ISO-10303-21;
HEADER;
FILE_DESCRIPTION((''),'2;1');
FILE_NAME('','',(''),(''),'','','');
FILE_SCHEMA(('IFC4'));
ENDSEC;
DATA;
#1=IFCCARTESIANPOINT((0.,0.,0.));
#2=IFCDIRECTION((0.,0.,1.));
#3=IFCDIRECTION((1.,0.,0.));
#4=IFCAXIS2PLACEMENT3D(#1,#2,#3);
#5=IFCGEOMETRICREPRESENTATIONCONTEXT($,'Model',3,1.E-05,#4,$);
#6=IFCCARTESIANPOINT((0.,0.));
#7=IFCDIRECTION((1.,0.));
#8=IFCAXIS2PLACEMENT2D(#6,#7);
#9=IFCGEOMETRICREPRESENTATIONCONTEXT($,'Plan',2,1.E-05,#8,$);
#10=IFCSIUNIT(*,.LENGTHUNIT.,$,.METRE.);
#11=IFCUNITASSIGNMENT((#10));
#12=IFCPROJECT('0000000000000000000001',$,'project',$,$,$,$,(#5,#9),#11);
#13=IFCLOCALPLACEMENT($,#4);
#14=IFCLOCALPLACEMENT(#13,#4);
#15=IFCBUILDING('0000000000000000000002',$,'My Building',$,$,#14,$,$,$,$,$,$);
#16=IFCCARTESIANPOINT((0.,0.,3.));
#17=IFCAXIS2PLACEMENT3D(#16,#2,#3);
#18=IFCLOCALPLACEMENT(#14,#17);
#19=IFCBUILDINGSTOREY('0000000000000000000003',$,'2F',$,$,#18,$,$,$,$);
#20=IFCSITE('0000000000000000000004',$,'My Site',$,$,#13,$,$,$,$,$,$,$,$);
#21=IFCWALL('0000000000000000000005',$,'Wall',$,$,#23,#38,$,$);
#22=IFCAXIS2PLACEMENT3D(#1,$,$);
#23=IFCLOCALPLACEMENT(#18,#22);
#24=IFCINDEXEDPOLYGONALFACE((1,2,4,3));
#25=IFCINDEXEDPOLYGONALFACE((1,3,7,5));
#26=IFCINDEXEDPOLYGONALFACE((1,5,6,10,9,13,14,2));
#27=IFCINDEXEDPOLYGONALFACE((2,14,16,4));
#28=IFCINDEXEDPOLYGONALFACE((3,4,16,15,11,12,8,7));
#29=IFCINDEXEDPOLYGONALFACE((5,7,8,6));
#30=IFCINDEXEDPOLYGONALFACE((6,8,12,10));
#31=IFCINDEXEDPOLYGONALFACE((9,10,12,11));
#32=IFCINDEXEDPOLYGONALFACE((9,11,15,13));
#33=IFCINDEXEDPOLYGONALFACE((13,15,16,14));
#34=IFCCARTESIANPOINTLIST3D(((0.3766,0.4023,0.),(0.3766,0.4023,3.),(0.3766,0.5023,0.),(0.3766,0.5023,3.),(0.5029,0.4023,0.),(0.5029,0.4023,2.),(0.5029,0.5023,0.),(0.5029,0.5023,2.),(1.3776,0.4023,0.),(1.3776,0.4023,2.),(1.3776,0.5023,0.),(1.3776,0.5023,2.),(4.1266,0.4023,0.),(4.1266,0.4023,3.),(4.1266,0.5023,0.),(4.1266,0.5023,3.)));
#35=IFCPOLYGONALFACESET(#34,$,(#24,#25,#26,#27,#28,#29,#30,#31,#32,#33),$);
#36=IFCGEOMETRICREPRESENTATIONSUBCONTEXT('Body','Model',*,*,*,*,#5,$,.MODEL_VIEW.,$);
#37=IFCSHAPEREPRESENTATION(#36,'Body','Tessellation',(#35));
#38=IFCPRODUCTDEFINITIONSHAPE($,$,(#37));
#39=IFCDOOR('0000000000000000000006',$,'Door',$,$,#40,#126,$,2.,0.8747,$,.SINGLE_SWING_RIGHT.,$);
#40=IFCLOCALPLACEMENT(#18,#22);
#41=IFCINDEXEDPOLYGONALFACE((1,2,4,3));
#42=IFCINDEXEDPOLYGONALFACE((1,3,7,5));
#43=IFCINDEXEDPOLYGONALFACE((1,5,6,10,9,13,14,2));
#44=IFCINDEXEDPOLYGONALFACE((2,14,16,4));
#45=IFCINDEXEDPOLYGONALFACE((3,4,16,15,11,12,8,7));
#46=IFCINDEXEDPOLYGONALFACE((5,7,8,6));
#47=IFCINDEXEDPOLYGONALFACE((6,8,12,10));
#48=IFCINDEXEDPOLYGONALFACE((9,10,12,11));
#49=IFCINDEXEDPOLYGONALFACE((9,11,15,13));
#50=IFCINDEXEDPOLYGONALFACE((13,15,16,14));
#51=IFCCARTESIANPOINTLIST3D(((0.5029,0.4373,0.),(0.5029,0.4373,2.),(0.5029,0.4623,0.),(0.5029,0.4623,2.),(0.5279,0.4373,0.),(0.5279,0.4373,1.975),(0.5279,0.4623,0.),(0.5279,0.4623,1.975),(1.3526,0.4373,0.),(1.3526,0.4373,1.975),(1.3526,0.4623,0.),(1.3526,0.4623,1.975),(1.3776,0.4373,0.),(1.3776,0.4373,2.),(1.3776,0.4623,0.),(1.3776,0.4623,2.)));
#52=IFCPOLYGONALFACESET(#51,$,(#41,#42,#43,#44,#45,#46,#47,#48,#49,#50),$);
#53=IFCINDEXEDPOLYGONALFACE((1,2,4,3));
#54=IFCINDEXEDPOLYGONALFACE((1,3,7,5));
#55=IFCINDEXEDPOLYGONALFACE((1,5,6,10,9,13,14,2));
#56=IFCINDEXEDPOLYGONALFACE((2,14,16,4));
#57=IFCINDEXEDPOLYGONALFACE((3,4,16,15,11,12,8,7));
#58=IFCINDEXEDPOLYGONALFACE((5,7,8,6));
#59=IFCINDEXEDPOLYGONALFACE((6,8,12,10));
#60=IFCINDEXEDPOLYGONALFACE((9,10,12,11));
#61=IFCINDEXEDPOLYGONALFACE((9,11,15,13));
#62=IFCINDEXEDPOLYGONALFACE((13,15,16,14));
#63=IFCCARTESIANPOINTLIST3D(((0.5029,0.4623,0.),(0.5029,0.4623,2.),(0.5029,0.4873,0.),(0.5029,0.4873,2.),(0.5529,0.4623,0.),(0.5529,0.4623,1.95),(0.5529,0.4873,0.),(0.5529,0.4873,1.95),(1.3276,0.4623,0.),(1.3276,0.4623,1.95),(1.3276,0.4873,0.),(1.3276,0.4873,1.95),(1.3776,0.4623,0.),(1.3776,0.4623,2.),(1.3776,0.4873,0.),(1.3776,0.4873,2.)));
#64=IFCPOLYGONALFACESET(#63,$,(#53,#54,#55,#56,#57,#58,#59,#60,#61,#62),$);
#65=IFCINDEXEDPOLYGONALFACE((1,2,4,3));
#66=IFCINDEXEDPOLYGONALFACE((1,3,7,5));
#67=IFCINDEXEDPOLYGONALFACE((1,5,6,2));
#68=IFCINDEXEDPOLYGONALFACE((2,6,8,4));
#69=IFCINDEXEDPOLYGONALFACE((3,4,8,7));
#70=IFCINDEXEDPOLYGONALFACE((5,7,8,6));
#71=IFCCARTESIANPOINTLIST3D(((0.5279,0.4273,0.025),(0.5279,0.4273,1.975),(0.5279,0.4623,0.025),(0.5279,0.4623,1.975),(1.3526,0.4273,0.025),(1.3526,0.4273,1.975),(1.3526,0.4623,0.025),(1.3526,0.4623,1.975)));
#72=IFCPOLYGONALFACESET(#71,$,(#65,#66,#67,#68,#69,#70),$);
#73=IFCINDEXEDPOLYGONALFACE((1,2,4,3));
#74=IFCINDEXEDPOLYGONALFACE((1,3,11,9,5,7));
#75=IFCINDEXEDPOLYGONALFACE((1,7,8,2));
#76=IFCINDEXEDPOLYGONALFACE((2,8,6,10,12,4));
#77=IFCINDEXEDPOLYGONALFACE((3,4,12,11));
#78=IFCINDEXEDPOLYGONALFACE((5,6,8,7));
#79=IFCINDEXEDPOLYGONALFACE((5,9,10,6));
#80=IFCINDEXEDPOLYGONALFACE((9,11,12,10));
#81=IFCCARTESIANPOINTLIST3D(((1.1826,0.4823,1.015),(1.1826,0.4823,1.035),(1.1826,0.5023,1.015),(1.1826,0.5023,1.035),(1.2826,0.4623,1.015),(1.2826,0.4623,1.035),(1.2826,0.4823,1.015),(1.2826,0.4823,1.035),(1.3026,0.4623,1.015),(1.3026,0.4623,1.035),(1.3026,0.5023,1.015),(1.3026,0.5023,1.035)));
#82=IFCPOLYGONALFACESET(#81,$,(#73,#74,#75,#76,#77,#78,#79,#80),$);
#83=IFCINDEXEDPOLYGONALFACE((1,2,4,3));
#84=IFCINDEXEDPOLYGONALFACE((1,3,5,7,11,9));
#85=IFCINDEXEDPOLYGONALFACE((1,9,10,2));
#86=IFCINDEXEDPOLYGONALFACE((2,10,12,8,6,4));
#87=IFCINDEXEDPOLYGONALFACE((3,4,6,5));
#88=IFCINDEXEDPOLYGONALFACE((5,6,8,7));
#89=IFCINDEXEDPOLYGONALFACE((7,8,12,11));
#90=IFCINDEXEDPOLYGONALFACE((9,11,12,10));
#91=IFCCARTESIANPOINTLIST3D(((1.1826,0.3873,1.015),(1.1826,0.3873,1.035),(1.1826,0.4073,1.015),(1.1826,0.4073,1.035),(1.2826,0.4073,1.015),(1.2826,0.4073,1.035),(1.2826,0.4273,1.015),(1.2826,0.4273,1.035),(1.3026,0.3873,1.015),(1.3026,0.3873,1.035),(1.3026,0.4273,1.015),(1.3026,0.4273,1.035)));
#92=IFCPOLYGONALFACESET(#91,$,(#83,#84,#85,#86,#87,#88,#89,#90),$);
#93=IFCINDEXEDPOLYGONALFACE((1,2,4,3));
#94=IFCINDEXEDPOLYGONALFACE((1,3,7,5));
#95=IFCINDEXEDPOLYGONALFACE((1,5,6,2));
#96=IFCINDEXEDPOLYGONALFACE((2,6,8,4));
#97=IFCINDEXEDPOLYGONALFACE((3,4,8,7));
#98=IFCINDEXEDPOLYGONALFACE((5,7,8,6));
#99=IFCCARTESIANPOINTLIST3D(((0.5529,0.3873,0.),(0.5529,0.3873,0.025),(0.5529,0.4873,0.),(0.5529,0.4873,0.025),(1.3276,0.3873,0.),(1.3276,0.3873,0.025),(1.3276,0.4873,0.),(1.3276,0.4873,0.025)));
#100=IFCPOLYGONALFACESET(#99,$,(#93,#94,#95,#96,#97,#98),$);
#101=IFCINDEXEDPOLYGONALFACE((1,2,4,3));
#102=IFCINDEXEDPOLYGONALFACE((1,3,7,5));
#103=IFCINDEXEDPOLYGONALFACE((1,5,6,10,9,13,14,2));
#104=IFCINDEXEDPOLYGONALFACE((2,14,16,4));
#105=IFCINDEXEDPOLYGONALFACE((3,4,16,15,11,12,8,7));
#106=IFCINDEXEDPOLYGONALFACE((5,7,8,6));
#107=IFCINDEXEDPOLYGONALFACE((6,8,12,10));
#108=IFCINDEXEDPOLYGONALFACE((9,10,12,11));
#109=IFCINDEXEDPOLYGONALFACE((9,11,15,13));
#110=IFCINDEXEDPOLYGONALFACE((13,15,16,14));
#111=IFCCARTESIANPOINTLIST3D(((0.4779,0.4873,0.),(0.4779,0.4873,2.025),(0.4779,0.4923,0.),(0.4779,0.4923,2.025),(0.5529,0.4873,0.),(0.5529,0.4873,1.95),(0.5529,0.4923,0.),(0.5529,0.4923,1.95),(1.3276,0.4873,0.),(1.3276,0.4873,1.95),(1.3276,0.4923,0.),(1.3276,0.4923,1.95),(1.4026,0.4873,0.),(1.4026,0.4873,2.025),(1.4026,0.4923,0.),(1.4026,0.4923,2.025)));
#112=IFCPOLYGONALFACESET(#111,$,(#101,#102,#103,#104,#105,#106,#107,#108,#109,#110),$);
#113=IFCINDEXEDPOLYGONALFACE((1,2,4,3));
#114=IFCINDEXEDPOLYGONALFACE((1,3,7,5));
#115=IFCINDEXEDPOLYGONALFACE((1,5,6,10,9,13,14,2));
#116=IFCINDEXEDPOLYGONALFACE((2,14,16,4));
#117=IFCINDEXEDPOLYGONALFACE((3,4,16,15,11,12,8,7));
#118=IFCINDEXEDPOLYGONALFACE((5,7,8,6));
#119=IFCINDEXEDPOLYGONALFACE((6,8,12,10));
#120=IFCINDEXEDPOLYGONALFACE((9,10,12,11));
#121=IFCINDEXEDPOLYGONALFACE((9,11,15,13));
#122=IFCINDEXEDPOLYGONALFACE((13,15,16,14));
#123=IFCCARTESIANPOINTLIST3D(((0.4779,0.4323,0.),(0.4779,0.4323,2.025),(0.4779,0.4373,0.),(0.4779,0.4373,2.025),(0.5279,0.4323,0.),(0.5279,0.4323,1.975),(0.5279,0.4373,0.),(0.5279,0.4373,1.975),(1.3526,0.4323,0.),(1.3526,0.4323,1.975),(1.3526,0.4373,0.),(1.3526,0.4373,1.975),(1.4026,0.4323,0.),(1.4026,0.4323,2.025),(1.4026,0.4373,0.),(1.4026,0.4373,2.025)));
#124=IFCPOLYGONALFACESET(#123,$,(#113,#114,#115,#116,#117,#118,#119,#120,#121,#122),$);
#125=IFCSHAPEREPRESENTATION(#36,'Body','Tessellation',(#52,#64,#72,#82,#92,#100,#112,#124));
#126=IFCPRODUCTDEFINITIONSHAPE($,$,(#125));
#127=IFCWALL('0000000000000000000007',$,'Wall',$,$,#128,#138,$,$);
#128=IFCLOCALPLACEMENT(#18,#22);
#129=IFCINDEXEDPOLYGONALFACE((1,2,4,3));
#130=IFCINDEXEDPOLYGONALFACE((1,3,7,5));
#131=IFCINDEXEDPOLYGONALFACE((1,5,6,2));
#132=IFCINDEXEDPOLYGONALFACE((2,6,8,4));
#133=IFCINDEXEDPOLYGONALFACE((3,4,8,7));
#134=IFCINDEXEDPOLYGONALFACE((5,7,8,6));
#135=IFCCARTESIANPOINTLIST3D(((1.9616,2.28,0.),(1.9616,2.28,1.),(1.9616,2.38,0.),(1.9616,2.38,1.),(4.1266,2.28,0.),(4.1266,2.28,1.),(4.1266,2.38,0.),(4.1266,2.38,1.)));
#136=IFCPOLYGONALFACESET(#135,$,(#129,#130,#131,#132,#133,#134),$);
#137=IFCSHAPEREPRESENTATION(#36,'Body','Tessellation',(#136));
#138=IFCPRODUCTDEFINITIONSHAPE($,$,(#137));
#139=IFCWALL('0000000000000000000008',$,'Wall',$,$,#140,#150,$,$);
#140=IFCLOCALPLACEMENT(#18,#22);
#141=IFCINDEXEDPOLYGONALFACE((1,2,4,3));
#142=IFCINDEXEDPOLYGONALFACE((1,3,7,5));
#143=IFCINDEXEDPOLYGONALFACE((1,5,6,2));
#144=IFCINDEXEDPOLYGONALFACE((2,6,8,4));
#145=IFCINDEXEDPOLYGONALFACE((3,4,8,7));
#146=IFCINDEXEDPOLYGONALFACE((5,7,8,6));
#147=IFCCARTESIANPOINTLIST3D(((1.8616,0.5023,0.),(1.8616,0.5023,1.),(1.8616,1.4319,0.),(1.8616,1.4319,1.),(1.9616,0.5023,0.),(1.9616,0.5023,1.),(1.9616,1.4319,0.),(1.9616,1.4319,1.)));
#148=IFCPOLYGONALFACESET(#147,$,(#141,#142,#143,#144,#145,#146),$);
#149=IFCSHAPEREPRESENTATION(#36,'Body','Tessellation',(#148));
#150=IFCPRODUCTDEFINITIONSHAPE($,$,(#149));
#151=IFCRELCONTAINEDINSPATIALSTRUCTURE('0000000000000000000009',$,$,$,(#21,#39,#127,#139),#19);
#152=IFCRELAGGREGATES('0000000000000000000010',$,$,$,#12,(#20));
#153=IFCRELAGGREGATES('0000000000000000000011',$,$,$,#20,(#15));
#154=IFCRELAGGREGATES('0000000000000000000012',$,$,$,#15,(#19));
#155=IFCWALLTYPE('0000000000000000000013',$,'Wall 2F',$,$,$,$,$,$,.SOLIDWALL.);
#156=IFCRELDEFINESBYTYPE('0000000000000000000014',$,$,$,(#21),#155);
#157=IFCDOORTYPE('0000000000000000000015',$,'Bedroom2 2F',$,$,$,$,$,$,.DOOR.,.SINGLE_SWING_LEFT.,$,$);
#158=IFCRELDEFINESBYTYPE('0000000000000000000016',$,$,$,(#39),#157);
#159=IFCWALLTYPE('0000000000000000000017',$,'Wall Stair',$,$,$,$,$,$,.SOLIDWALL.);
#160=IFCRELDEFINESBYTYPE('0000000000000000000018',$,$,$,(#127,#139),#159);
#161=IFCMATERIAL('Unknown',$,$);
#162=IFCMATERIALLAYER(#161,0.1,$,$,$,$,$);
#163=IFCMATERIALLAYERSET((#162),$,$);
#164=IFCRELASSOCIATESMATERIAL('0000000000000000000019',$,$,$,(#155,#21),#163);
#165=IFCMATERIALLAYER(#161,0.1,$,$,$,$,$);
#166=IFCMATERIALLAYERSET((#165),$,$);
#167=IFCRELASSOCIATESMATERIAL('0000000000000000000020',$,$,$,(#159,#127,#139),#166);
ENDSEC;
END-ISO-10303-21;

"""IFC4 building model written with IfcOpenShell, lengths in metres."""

from ifc_helpers import new_model, entity, si_unit, frame, origin_with_axes, origin_2d_with_axis, place, context, subcontext, project, spatial, line, indexed_curve, outline, extrude, shape, source, transform, mapped, material, layer, layer_set, layer_usage, type_object, type_shapes, element, fill, save


model = new_model("IFC4")

# Units and contexts
model_context = context("Model", 3, precision=1e-05, world=origin_with_axes())
plan_context = context("Plan", 2, precision=1e-05, world=origin_2d_with_axis())
body_context_1 = subcontext(model_context, "Body", "Model", "MODEL_VIEW")
body_context_2 = subcontext(plan_context, "Body", "Plan", "PLAN_VIEW")
ifc_project = project(units=[si_unit("LENGTHUNIT", "METRE")], contexts=[model_context, plan_context])

# Site, building, storey
site_placement = place(None, origin_with_axes())
site = spatial("IfcSite", under=ifc_project, at=site_placement, Name="My Site")
building_placement = place(site_placement, origin_with_axes())
building = spatial("IfcBuilding", under=site, at=building_placement, Name="My Building")
storey_placement = place(building_placement, frame((0.0, 0.0, 3.0), z_axis=(0.0, 0.0, 1.0), x_axis=(1.0, 0.0, 0.0)))
storey = spatial("IfcBuildingStorey", under=building, at=storey_placement, Name="2F")

# Shared definitions
ifc_material = material(Name="Unknown")
ifc_layer_1 = layer(ifc_material, 0.1)
ifc_layer_set_1 = layer_set([ifc_layer_1])
wall_type_1 = type_object("IfcWallType", Name="Wall 2F", PredefinedType="SOLIDWALL", material=ifc_layer_set_1)

# Wall, opening, door
ifc_layer_usage_1 = layer_usage(ifc_layer_set_1, "AXIS2", "POSITIVE", 0.0)
wall_1_placement = place(storey_placement, frame((4.2266, 0.5023, 0.0), z_axis=(0.0, 0.0, 1.0), x_axis=(-1.0, 0.0, 0.0)))
wall_1 = element("IfcWall", 1, at=wall_1_placement, inside=storey, type_object=wall_type_1, material=ifc_layer_usage_1, Name="Wall", context=body_context_1, shape_type="SweptSolid", body=[
    extrude(outline(indexed_curve([(0.1, 0.0), (0.1, 0.1), (3.85, 0.1), (3.85, 0.0)], segments=[line(1, 2, 3, 4, 1)])), origin_with_axes(), (0.0, 0.0, 1.0), 3.0),
])
shared_shape_1 = source(origin_with_axes(), body_context_1, "Body", "SweptSolid", [
    extrude(outline(indexed_curve([(0.0, 0.0), (0.8747, 0.0), (0.8747, 2.0), (0.0, 2.0)], segments=[line(1, 2, 3, 4, 1)])), frame((0.0, -0.6, 0.0), z_axis=(0.0, -1.0, 0.0), x_axis=(1.0, 0.0, 0.0)), (0.0, 0.0, -1.0), 1.2),
])
opening_1_placement = place(wall_1_placement, frame((2.849, 0.015, 0.0), z_axis=(0.0, 0.0, 1.0), x_axis=(1.0, -0.000001, 0.0)))
opening_1 = element("IfcOpeningElement", 2, at=opening_1_placement, cuts=wall_1, PredefinedType="OPENING", context=body_context_1, shape_type="MappedRepresentation", body=[
    mapped(shared_shape_1, transform((0.0, 0.0, 0.0), x_axis=(1.0, 0.0, 0.0), y_axis=(0.0, 1.0, 0.0), z_axis=(0.0, 0.0, 1.0), scale=1.0)),
])
door_type_1 = type_object("IfcDoorType", Name="Bedroom2 2F", OperationType="SINGLE_SWING_LEFT", PredefinedType="DOOR")
shared_shape_2 = source(origin_with_axes(), body_context_1, "Body", "SweptSolid", [
    extrude(outline(indexed_curve([(0.0, 0.0), (0.0, 2.0), (0.8747, 2.0), (0.8747, 0.0), (0.8497, 0.0), (0.8497, 1.975), (0.025, 1.975), (0.025, 0.0)], segments=[line(1, 2, 3, 4, 5, 6, 7, 8, 1)])), frame((0.0, 0.025, 0.0), z_axis=(0.0, -1.0, 0.0), x_axis=(1.0, 0.0, 0.0)), (0.0, 0.0, -1.0), 0.025),
    extrude(outline(indexed_curve([(0.0, 0.0), (0.0, 2.0), (0.8747, 2.0), (0.8747, 0.0), (0.8247, 0.0), (0.8247, 1.95), (0.05, 1.95), (0.05, 0.0)], segments=[line(1, 2, 3, 4, 5, 6, 7, 8, 1)])), frame((0.0, 0.0, 0.0), z_axis=(0.0, -1.0, 0.0), x_axis=(1.0, 0.0, 0.0)), (0.0, 0.0, -1.0), 0.025),
    extrude(outline(indexed_curve([(0.0, 0.0), (0.8247, 0.0), (0.8247, 0.035), (0.0, 0.035)], segments=[line(1, 2, 3, 4, 1)])), frame((0.025, 0.025, 0.025), z_axis=(0.0, 0.0, 1.0), x_axis=(1.0, 0.0, 0.0)), (0.0, 0.0, 1.0), 1.95),
    extrude(outline(indexed_curve([(0.0, 0.0), (0.0, -0.04), (0.12, -0.04), (0.12, -0.02), (0.02, -0.02), (0.02, 0.0)], segments=[line(1, 2, 3, 4, 5, 6, 1)])), frame((0.075, 0.025, 1.015), z_axis=(0.0, 0.0, 1.0), x_axis=(1.0, 0.0, 0.0)), (0.0, 0.0, 1.0), 0.02),
    extrude(outline(indexed_curve([(0.0, 0.0), (0.0, 0.04), (0.12, 0.04), (0.12, 0.02), (0.02, 0.02), (0.02, 0.0)], segments=[line(1, 2, 3, 4, 5, 6, 1)])), frame((0.075, 0.06, 1.015), z_axis=(0.0, 0.0, 1.0), x_axis=(1.0, 0.0, 0.0)), (0.0, 0.0, 1.0), 0.02),
    extrude(outline(indexed_curve([(0.0, 0.0), (0.7747, 0.0), (0.7747, 0.1), (0.0, 0.1)], segments=[line(1, 2, 3, 4, 1)])), frame((0.05, 0.0, 0.0), z_axis=(0.0, 0.0, 1.0), x_axis=(1.0, 0.0, 0.0)), (0.0, 0.0, 1.0), 0.025),
    extrude(outline(indexed_curve([(0.0, 0.0), (0.0, 2.025), (0.9247, 2.025), (0.9247, 0.0), (0.8497, 0.0), (0.8497, 1.95), (0.075, 1.95), (0.075, 0.0)], segments=[line(1, 2, 3, 4, 5, 6, 7, 8, 1)])), frame((-0.025, -0.005, 0.0), z_axis=(0.0, -1.0, 0.0), x_axis=(1.0, 0.0, 0.0)), (0.0, 0.0, -1.0), 0.005),
    extrude(outline(indexed_curve([(0.0, 0.0), (0.0, 2.025), (0.9247, 2.025), (0.9247, 0.0), (0.8747, 0.0), (0.8747, 1.975), (0.05, 1.975), (0.05, 0.0)], segments=[line(1, 2, 3, 4, 5, 6, 7, 8, 1)])), frame((-0.025, 0.05, 0.0), z_axis=(0.0, -1.0, 0.0), x_axis=(1.0, 0.0, 0.0)), (0.0, 0.0, -1.0), 0.005),
])
shared_shape_3 = source(origin_with_axes(), body_context_2, "Body", "Curve2D", [
    entity("IfcIndexedPolyCurve", entity("IfcCartesianPointList2D", [[0.0, 0.0], [0.0, 0.05], [0.025, 0.05], [0.025, 0.025], [0.05, 0.025], [0.05, 0.0]]), [entity("IfcLineIndex", [1, 2, 3, 4, 5, 6, 1])]),
    entity("IfcIndexedPolyCurve", entity("IfcCartesianPointList2D", [[0.8747, 0.0], [0.8747, 0.05], [0.8497, 0.05], [0.8497, 0.025], [0.8247, 0.025], [0.8247, 0.0]]), [entity("IfcLineIndex", [1, 2, 3, 4, 5, 6, 1])]),
    entity("IfcTrimmedCurve", entity("IfcEllipse", entity("IfcAxis2Placement2D", entity("IfcCartesianPoint", [0.8147, 0.05]), entity("IfcDirection", [1.0, 0.0])), 0.7897, 0.8247), [entity("IfcCartesianPoint", [0.8147, 0.8747])], [entity("IfcCartesianPoint", [0.025, 0.05])], True, "CARTESIAN"),
    entity("IfcIndexedPolyCurve", entity("IfcCartesianPointList2D", [[0.8497, 0.05], [0.8147, 0.05], [0.8147, 0.8747], [0.8497, 0.8747]]), [entity("IfcLineIndex", [1, 2, 3, 4, 1])]),
])
type_shapes(door_type_1, [shared_shape_2, shared_shape_3])
door_1_placement = place(opening_1_placement, frame((0.0, 0.0, 0.0), z_axis=(0.0, 0.0, 1.0), x_axis=(1.0, 0.0, 0.0)))
door_1 = element("IfcDoor", 3, at=door_1_placement, inside=storey, type_object=door_type_1, Name="Door", OperationType="SINGLE_SWING_RIGHT", OverallHeight=2.0, OverallWidth=0.8747, shapes=[
    shape(body_context_1, "Body", "MappedRepresentation", [mapped(shared_shape_2, transform((0.0, 0.0, 0.0), x_axis=(1.0, 0.0, 0.0), y_axis=(0.0, 1.0, 0.0), z_axis=(0.0, 0.0, 1.0), scale=1.0))]),
    shape(body_context_2, "Body", "MappedRepresentation", [mapped(shared_shape_3, transform((0.0, 0.0, 0.0), x_axis=(1.0, 0.0, 0.0), y_axis=(0.0, 1.0, 0.0), z_axis=(0.0, 0.0, 1.0), scale=1.0))]),
])
fill(opening_1, door_1)

# Walls
ifc_layer_2 = layer(ifc_material, 0.1)
ifc_layer_set_2 = layer_set([ifc_layer_2])
ifc_layer_usage_2 = layer_usage(ifc_layer_set_2, "AXIS2", "POSITIVE", 0.0)
wall_type_2 = type_object("IfcWallType", Name="Wall Stair", PredefinedType="SOLIDWALL", material=ifc_layer_set_2)
wall_2_placement = place(storey_placement, frame((1.9616, 2.28, 0.0), z_axis=(0.0, 0.0, 1.0), x_axis=(1.0, 0.0, 0.0)))
element("IfcWall", 4, at=wall_2_placement, inside=storey, type_object=wall_type_2, material=ifc_layer_usage_2, Name="Wall", context=body_context_1, shape_type="SweptSolid", body=[
    extrude(outline(indexed_curve([(0.0, 0.0), (0.0, 0.1), (2.165, 0.1), (2.165, 0.0)], segments=[line(1, 2, 3, 4, 1)])), origin_with_axes(), (0.0, 0.0, 1.0), 1.0),
])
ifc_layer_usage_3 = layer_usage(ifc_layer_set_2, "AXIS2", "POSITIVE", 0.0)
wall_3_placement = place(storey_placement, frame((1.9616, 0.5023, 0.0), z_axis=(0.0, 0.0, 1.0), x_axis=(0.0, 1.0, 0.0)))
element("IfcWall", 5, at=wall_3_placement, inside=storey, type_object=wall_type_2, material=ifc_layer_usage_3, Name="Wall", context=body_context_1, shape_type="SweptSolid", body=[
    extrude(outline(indexed_curve([(0.0, 0.0), (0.0, 0.1), (0.9296, 0.1), (0.9296, 0.0)], segments=[line(1, 2, 3, 4, 1)])), origin_with_axes(), (0.0, 0.0, 1.0), 1.0),
])

save(model, "model.ifc")
